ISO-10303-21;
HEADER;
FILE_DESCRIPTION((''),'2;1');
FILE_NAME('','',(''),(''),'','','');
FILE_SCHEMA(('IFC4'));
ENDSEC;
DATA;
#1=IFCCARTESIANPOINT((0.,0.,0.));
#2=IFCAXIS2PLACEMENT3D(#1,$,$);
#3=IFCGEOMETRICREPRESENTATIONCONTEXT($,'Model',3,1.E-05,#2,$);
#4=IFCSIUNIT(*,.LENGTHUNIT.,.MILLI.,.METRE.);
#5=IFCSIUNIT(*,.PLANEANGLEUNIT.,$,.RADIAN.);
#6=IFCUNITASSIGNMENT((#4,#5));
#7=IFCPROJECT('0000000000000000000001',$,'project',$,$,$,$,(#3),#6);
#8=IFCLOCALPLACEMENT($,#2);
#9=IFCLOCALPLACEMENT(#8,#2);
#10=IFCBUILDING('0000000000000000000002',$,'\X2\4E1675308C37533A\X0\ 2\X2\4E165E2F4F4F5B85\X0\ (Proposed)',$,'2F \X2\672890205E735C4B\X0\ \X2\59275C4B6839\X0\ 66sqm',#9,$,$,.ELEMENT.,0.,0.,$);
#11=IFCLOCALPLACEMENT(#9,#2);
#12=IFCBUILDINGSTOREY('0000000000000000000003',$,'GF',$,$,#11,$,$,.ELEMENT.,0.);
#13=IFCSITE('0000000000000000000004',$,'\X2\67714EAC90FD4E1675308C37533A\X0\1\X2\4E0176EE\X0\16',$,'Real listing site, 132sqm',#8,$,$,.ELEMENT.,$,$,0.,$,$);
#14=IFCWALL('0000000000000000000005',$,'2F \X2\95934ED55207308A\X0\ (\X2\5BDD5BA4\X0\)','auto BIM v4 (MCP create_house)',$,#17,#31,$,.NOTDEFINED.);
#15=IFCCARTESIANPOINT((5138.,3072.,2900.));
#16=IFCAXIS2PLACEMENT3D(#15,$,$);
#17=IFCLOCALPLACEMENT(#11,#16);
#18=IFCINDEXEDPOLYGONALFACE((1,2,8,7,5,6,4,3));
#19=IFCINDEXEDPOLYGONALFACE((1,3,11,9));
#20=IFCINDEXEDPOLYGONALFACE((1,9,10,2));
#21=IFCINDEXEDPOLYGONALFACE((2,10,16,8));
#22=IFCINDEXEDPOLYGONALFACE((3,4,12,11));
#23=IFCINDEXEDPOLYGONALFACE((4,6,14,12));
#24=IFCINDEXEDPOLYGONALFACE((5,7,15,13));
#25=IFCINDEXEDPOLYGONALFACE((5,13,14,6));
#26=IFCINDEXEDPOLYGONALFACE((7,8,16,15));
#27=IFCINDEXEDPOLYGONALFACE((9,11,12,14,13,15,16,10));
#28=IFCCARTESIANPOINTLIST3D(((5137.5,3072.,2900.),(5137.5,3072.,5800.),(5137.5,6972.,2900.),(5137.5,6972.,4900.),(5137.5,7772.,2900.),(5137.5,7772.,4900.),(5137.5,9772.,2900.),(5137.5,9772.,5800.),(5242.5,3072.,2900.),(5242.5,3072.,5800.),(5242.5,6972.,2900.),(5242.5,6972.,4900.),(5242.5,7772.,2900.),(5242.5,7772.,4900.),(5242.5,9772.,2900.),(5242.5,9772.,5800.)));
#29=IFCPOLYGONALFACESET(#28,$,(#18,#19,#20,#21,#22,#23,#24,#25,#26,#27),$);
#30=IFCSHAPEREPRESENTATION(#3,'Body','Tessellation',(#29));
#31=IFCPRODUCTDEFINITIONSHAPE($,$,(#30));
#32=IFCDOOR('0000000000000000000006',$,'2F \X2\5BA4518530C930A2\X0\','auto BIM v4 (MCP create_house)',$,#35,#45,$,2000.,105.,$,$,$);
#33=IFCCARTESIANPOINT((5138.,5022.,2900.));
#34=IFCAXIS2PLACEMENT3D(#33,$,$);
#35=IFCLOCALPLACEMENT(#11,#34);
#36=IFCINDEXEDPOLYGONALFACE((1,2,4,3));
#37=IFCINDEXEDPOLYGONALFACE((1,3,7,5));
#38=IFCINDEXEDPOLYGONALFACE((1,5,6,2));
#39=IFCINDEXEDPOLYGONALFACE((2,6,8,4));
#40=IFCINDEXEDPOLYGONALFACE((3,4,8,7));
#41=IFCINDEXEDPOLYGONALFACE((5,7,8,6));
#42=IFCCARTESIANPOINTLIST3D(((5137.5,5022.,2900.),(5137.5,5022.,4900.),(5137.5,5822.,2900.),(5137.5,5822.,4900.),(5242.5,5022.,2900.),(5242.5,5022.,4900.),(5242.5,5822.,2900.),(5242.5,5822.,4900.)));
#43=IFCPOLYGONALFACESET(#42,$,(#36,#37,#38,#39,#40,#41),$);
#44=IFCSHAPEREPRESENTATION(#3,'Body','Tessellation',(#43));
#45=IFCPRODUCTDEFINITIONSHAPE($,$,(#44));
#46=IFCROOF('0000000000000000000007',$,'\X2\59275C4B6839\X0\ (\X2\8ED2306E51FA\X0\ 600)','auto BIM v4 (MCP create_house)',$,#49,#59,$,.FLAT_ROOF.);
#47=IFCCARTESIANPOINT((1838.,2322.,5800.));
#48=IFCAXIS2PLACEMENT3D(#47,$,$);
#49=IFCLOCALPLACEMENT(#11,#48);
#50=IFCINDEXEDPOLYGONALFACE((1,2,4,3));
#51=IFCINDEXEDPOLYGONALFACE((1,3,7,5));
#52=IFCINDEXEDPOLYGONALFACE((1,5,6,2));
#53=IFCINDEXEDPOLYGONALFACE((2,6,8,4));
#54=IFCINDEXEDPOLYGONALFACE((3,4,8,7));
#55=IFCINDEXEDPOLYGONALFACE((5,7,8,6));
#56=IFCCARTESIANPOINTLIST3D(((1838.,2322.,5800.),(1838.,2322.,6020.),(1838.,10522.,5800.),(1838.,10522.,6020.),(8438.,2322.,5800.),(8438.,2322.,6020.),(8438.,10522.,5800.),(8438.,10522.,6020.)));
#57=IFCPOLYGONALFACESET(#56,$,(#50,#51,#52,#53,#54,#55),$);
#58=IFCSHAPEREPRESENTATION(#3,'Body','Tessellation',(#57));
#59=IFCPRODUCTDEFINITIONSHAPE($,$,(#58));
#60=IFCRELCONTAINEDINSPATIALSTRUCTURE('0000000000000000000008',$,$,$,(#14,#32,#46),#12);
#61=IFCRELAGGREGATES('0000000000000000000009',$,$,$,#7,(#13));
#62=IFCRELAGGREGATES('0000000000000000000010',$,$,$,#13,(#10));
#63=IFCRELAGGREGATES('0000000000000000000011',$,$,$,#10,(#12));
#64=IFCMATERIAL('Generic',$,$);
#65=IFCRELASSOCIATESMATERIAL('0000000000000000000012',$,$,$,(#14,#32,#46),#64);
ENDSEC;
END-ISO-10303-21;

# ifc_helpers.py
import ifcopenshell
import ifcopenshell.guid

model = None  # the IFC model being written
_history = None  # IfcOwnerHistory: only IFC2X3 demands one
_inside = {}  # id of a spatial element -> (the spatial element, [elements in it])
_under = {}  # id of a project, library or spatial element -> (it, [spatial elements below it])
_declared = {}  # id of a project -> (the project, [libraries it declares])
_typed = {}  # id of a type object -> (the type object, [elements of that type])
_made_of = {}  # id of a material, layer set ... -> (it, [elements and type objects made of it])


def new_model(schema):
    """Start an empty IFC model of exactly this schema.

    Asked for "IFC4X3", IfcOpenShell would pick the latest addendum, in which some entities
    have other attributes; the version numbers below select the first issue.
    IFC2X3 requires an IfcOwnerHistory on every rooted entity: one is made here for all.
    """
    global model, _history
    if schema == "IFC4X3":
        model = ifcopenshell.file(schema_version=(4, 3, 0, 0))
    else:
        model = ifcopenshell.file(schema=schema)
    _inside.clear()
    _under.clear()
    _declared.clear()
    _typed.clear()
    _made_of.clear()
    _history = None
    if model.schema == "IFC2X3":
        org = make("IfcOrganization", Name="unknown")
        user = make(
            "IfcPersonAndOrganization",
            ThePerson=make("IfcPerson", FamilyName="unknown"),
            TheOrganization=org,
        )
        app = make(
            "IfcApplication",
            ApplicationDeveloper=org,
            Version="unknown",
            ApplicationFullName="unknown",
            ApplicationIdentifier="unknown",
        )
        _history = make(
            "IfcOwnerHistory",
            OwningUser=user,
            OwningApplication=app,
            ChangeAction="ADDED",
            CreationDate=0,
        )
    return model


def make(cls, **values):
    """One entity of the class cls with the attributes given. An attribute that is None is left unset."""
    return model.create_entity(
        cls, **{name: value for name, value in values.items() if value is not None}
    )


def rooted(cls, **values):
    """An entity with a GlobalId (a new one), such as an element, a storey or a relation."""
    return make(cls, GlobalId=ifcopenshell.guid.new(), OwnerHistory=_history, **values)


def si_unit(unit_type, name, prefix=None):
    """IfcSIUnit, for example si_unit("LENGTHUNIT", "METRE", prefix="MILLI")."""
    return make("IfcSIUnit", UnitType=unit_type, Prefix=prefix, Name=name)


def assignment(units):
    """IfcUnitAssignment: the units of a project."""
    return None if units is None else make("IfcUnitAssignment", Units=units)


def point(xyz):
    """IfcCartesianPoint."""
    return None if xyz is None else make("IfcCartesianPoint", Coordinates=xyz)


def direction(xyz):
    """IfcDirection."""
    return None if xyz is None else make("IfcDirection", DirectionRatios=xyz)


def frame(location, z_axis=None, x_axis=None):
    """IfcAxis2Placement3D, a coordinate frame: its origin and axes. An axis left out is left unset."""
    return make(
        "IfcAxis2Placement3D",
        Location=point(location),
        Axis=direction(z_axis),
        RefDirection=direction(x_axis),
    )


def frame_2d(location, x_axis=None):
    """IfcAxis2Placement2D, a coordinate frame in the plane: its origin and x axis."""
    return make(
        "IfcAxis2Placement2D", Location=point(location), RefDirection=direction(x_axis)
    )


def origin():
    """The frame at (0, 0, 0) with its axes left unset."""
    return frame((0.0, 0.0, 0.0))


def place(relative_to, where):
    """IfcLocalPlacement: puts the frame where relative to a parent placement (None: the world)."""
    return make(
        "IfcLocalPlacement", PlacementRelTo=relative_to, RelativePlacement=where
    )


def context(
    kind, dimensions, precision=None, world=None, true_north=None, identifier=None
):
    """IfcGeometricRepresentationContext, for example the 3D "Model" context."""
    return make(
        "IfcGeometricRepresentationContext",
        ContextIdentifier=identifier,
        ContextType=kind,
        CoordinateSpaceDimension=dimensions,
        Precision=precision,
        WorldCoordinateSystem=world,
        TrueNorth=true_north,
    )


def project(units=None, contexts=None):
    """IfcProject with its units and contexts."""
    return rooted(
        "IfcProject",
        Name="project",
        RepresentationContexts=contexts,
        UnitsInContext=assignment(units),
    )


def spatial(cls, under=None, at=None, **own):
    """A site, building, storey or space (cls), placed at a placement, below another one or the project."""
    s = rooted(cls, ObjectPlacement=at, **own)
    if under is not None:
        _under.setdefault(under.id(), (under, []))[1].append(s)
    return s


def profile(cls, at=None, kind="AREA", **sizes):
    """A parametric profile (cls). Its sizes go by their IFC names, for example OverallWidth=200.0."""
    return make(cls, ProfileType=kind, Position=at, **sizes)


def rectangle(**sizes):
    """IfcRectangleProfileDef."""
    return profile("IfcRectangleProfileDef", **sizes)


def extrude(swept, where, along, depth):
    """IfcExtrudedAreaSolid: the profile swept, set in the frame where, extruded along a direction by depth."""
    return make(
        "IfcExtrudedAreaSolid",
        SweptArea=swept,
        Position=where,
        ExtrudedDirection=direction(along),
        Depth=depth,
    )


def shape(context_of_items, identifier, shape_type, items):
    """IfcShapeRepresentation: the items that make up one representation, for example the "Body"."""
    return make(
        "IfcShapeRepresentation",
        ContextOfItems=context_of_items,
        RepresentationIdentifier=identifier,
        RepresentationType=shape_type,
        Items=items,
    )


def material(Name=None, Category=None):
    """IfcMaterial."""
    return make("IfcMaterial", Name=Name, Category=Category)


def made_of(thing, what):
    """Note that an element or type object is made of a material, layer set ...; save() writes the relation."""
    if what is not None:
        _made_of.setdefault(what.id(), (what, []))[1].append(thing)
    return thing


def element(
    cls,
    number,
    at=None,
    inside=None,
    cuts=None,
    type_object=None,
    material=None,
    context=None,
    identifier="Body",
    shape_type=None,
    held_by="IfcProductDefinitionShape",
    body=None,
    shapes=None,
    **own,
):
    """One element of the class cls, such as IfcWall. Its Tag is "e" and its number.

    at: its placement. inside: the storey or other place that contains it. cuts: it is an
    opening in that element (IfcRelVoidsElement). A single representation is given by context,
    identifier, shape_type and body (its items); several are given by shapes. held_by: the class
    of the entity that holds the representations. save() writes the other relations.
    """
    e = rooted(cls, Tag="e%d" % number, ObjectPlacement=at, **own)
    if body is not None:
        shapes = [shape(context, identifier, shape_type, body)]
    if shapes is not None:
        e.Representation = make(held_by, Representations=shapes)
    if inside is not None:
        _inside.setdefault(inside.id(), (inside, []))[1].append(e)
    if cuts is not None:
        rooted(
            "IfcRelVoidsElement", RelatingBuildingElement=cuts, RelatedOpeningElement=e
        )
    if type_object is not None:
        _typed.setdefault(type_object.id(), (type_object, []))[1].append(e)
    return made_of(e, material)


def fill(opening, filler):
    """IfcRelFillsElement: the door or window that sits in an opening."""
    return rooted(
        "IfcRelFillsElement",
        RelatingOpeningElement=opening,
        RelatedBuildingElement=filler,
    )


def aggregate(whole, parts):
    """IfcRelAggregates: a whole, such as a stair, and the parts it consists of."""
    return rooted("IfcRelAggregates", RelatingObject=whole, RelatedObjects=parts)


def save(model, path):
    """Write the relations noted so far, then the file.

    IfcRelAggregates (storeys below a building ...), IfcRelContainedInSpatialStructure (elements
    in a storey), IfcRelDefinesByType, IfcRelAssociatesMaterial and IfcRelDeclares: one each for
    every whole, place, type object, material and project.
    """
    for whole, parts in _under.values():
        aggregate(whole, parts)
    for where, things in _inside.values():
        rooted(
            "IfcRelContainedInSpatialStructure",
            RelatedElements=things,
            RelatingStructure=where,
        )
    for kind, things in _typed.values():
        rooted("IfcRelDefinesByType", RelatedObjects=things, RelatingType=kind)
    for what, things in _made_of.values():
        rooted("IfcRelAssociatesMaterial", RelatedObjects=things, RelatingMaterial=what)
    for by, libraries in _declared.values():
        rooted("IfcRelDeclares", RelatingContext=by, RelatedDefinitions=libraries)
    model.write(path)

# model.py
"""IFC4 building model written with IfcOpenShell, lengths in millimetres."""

from ifc_helpers import new_model, si_unit, frame, frame_2d, origin, place, context, project, spatial, rectangle, extrude, material, element, fill, save


model = new_model("IFC4")

# Units and contexts
model_context = context("Model", 3, precision=1e-05, world=origin())
ifc_project = project(units=[si_unit("LENGTHUNIT", "METRE", prefix="MILLI"), si_unit("PLANEANGLEUNIT", "RADIAN")], contexts=[model_context])

# Site, building, storey
site_placement = place(None, origin())
site = spatial("IfcSite", under=ifc_project, at=site_placement, Name="東京都世田谷区1丁目16", ObjectType="Real listing site, 132sqm", CompositionType="ELEMENT", RefElevation=0.0)
building_placement = place(site_placement, origin())
building = spatial("IfcBuilding", under=site, at=building_placement, Name="世田谷区 2世帯住宅 (Proposed)", ObjectType="2F 木造平屋 大屋根 66sqm", CompositionType="ELEMENT", ElevationOfRefHeight=0.0, ElevationOfTerrain=0.0)
storey_placement = place(building_placement, origin())
storey = spatial("IfcBuildingStorey", under=building, at=storey_placement, Name="GF", CompositionType="ELEMENT", Elevation=0.0)

# Shared definitions
ifc_material = material(Name="Generic")

# Wall, opening, door
wall_1_placement = place(storey_placement, frame((5138.0, 3072.0, 2900.0)))
wall_1 = element("IfcWall", 1, at=wall_1_placement, inside=storey, material=ifc_material, Name="2F 間仕切り (寝室)", Description="auto BIM v4 (MCP create_house)", PredefinedType="NOTDEFINED", context=model_context, shape_type="SweptSolid", body=[
    extrude(rectangle(XDim=105.0, YDim=6700.0, at=frame_2d((52.0, 3350.0))), frame((5138.0, 3072.0, 2900.0)), (0.0, 0.0, 1.0), 2900.0),
])
opening_1_placement = place(storey_placement, frame((5138.0, 5022.0, 2900.0)))
opening_1 = element("IfcOpeningElement", 2, at=opening_1_placement, cuts=wall_1, PredefinedType="NOTDEFINED", context=model_context, shape_type="SweptSolid", body=[
    extrude(rectangle(XDim=105.0, YDim=800.0, at=frame_2d((52.0, 400.0))), frame((5138.0, 5022.0, 2900.0)), (0.0, 0.0, 1.0), 2000.0),
])
door_1_placement = place(storey_placement, frame((5138.0, 5022.0, 2900.0)))
door_1 = element("IfcDoor", 3, at=door_1_placement, inside=storey, material=ifc_material, Name="2F 室内ドア", Description="auto BIM v4 (MCP create_house)", OverallHeight=2000.0, OverallWidth=105.0, context=model_context, shape_type="SweptSolid", body=[
    extrude(rectangle(XDim=105.0, YDim=800.0, at=frame_2d((52.0, 400.0))), frame((5138.0, 5022.0, 2900.0)), (0.0, 0.0, 1.0), 2000.0),
])
fill(opening_1, door_1)

# Roof
roof_placement = place(storey_placement, frame((1838.0, 2322.0, 5800.0)))
element("IfcRoof", 4, at=roof_placement, inside=storey, material=ifc_material, Name="大屋根 (軒の出 600)", Description="auto BIM v4 (MCP create_house)", PredefinedType="FLAT_ROOF", context=model_context, shape_type="SweptSolid", body=[
    extrude(rectangle(XDim=6600.0, YDim=8200.0, at=frame_2d((3300.0, 4100.0))), frame((1838.0, 2322.0, 5800.0)), (0.0, 0.0, 1.0), 220.0),
])

save(model, "model.ifc")
